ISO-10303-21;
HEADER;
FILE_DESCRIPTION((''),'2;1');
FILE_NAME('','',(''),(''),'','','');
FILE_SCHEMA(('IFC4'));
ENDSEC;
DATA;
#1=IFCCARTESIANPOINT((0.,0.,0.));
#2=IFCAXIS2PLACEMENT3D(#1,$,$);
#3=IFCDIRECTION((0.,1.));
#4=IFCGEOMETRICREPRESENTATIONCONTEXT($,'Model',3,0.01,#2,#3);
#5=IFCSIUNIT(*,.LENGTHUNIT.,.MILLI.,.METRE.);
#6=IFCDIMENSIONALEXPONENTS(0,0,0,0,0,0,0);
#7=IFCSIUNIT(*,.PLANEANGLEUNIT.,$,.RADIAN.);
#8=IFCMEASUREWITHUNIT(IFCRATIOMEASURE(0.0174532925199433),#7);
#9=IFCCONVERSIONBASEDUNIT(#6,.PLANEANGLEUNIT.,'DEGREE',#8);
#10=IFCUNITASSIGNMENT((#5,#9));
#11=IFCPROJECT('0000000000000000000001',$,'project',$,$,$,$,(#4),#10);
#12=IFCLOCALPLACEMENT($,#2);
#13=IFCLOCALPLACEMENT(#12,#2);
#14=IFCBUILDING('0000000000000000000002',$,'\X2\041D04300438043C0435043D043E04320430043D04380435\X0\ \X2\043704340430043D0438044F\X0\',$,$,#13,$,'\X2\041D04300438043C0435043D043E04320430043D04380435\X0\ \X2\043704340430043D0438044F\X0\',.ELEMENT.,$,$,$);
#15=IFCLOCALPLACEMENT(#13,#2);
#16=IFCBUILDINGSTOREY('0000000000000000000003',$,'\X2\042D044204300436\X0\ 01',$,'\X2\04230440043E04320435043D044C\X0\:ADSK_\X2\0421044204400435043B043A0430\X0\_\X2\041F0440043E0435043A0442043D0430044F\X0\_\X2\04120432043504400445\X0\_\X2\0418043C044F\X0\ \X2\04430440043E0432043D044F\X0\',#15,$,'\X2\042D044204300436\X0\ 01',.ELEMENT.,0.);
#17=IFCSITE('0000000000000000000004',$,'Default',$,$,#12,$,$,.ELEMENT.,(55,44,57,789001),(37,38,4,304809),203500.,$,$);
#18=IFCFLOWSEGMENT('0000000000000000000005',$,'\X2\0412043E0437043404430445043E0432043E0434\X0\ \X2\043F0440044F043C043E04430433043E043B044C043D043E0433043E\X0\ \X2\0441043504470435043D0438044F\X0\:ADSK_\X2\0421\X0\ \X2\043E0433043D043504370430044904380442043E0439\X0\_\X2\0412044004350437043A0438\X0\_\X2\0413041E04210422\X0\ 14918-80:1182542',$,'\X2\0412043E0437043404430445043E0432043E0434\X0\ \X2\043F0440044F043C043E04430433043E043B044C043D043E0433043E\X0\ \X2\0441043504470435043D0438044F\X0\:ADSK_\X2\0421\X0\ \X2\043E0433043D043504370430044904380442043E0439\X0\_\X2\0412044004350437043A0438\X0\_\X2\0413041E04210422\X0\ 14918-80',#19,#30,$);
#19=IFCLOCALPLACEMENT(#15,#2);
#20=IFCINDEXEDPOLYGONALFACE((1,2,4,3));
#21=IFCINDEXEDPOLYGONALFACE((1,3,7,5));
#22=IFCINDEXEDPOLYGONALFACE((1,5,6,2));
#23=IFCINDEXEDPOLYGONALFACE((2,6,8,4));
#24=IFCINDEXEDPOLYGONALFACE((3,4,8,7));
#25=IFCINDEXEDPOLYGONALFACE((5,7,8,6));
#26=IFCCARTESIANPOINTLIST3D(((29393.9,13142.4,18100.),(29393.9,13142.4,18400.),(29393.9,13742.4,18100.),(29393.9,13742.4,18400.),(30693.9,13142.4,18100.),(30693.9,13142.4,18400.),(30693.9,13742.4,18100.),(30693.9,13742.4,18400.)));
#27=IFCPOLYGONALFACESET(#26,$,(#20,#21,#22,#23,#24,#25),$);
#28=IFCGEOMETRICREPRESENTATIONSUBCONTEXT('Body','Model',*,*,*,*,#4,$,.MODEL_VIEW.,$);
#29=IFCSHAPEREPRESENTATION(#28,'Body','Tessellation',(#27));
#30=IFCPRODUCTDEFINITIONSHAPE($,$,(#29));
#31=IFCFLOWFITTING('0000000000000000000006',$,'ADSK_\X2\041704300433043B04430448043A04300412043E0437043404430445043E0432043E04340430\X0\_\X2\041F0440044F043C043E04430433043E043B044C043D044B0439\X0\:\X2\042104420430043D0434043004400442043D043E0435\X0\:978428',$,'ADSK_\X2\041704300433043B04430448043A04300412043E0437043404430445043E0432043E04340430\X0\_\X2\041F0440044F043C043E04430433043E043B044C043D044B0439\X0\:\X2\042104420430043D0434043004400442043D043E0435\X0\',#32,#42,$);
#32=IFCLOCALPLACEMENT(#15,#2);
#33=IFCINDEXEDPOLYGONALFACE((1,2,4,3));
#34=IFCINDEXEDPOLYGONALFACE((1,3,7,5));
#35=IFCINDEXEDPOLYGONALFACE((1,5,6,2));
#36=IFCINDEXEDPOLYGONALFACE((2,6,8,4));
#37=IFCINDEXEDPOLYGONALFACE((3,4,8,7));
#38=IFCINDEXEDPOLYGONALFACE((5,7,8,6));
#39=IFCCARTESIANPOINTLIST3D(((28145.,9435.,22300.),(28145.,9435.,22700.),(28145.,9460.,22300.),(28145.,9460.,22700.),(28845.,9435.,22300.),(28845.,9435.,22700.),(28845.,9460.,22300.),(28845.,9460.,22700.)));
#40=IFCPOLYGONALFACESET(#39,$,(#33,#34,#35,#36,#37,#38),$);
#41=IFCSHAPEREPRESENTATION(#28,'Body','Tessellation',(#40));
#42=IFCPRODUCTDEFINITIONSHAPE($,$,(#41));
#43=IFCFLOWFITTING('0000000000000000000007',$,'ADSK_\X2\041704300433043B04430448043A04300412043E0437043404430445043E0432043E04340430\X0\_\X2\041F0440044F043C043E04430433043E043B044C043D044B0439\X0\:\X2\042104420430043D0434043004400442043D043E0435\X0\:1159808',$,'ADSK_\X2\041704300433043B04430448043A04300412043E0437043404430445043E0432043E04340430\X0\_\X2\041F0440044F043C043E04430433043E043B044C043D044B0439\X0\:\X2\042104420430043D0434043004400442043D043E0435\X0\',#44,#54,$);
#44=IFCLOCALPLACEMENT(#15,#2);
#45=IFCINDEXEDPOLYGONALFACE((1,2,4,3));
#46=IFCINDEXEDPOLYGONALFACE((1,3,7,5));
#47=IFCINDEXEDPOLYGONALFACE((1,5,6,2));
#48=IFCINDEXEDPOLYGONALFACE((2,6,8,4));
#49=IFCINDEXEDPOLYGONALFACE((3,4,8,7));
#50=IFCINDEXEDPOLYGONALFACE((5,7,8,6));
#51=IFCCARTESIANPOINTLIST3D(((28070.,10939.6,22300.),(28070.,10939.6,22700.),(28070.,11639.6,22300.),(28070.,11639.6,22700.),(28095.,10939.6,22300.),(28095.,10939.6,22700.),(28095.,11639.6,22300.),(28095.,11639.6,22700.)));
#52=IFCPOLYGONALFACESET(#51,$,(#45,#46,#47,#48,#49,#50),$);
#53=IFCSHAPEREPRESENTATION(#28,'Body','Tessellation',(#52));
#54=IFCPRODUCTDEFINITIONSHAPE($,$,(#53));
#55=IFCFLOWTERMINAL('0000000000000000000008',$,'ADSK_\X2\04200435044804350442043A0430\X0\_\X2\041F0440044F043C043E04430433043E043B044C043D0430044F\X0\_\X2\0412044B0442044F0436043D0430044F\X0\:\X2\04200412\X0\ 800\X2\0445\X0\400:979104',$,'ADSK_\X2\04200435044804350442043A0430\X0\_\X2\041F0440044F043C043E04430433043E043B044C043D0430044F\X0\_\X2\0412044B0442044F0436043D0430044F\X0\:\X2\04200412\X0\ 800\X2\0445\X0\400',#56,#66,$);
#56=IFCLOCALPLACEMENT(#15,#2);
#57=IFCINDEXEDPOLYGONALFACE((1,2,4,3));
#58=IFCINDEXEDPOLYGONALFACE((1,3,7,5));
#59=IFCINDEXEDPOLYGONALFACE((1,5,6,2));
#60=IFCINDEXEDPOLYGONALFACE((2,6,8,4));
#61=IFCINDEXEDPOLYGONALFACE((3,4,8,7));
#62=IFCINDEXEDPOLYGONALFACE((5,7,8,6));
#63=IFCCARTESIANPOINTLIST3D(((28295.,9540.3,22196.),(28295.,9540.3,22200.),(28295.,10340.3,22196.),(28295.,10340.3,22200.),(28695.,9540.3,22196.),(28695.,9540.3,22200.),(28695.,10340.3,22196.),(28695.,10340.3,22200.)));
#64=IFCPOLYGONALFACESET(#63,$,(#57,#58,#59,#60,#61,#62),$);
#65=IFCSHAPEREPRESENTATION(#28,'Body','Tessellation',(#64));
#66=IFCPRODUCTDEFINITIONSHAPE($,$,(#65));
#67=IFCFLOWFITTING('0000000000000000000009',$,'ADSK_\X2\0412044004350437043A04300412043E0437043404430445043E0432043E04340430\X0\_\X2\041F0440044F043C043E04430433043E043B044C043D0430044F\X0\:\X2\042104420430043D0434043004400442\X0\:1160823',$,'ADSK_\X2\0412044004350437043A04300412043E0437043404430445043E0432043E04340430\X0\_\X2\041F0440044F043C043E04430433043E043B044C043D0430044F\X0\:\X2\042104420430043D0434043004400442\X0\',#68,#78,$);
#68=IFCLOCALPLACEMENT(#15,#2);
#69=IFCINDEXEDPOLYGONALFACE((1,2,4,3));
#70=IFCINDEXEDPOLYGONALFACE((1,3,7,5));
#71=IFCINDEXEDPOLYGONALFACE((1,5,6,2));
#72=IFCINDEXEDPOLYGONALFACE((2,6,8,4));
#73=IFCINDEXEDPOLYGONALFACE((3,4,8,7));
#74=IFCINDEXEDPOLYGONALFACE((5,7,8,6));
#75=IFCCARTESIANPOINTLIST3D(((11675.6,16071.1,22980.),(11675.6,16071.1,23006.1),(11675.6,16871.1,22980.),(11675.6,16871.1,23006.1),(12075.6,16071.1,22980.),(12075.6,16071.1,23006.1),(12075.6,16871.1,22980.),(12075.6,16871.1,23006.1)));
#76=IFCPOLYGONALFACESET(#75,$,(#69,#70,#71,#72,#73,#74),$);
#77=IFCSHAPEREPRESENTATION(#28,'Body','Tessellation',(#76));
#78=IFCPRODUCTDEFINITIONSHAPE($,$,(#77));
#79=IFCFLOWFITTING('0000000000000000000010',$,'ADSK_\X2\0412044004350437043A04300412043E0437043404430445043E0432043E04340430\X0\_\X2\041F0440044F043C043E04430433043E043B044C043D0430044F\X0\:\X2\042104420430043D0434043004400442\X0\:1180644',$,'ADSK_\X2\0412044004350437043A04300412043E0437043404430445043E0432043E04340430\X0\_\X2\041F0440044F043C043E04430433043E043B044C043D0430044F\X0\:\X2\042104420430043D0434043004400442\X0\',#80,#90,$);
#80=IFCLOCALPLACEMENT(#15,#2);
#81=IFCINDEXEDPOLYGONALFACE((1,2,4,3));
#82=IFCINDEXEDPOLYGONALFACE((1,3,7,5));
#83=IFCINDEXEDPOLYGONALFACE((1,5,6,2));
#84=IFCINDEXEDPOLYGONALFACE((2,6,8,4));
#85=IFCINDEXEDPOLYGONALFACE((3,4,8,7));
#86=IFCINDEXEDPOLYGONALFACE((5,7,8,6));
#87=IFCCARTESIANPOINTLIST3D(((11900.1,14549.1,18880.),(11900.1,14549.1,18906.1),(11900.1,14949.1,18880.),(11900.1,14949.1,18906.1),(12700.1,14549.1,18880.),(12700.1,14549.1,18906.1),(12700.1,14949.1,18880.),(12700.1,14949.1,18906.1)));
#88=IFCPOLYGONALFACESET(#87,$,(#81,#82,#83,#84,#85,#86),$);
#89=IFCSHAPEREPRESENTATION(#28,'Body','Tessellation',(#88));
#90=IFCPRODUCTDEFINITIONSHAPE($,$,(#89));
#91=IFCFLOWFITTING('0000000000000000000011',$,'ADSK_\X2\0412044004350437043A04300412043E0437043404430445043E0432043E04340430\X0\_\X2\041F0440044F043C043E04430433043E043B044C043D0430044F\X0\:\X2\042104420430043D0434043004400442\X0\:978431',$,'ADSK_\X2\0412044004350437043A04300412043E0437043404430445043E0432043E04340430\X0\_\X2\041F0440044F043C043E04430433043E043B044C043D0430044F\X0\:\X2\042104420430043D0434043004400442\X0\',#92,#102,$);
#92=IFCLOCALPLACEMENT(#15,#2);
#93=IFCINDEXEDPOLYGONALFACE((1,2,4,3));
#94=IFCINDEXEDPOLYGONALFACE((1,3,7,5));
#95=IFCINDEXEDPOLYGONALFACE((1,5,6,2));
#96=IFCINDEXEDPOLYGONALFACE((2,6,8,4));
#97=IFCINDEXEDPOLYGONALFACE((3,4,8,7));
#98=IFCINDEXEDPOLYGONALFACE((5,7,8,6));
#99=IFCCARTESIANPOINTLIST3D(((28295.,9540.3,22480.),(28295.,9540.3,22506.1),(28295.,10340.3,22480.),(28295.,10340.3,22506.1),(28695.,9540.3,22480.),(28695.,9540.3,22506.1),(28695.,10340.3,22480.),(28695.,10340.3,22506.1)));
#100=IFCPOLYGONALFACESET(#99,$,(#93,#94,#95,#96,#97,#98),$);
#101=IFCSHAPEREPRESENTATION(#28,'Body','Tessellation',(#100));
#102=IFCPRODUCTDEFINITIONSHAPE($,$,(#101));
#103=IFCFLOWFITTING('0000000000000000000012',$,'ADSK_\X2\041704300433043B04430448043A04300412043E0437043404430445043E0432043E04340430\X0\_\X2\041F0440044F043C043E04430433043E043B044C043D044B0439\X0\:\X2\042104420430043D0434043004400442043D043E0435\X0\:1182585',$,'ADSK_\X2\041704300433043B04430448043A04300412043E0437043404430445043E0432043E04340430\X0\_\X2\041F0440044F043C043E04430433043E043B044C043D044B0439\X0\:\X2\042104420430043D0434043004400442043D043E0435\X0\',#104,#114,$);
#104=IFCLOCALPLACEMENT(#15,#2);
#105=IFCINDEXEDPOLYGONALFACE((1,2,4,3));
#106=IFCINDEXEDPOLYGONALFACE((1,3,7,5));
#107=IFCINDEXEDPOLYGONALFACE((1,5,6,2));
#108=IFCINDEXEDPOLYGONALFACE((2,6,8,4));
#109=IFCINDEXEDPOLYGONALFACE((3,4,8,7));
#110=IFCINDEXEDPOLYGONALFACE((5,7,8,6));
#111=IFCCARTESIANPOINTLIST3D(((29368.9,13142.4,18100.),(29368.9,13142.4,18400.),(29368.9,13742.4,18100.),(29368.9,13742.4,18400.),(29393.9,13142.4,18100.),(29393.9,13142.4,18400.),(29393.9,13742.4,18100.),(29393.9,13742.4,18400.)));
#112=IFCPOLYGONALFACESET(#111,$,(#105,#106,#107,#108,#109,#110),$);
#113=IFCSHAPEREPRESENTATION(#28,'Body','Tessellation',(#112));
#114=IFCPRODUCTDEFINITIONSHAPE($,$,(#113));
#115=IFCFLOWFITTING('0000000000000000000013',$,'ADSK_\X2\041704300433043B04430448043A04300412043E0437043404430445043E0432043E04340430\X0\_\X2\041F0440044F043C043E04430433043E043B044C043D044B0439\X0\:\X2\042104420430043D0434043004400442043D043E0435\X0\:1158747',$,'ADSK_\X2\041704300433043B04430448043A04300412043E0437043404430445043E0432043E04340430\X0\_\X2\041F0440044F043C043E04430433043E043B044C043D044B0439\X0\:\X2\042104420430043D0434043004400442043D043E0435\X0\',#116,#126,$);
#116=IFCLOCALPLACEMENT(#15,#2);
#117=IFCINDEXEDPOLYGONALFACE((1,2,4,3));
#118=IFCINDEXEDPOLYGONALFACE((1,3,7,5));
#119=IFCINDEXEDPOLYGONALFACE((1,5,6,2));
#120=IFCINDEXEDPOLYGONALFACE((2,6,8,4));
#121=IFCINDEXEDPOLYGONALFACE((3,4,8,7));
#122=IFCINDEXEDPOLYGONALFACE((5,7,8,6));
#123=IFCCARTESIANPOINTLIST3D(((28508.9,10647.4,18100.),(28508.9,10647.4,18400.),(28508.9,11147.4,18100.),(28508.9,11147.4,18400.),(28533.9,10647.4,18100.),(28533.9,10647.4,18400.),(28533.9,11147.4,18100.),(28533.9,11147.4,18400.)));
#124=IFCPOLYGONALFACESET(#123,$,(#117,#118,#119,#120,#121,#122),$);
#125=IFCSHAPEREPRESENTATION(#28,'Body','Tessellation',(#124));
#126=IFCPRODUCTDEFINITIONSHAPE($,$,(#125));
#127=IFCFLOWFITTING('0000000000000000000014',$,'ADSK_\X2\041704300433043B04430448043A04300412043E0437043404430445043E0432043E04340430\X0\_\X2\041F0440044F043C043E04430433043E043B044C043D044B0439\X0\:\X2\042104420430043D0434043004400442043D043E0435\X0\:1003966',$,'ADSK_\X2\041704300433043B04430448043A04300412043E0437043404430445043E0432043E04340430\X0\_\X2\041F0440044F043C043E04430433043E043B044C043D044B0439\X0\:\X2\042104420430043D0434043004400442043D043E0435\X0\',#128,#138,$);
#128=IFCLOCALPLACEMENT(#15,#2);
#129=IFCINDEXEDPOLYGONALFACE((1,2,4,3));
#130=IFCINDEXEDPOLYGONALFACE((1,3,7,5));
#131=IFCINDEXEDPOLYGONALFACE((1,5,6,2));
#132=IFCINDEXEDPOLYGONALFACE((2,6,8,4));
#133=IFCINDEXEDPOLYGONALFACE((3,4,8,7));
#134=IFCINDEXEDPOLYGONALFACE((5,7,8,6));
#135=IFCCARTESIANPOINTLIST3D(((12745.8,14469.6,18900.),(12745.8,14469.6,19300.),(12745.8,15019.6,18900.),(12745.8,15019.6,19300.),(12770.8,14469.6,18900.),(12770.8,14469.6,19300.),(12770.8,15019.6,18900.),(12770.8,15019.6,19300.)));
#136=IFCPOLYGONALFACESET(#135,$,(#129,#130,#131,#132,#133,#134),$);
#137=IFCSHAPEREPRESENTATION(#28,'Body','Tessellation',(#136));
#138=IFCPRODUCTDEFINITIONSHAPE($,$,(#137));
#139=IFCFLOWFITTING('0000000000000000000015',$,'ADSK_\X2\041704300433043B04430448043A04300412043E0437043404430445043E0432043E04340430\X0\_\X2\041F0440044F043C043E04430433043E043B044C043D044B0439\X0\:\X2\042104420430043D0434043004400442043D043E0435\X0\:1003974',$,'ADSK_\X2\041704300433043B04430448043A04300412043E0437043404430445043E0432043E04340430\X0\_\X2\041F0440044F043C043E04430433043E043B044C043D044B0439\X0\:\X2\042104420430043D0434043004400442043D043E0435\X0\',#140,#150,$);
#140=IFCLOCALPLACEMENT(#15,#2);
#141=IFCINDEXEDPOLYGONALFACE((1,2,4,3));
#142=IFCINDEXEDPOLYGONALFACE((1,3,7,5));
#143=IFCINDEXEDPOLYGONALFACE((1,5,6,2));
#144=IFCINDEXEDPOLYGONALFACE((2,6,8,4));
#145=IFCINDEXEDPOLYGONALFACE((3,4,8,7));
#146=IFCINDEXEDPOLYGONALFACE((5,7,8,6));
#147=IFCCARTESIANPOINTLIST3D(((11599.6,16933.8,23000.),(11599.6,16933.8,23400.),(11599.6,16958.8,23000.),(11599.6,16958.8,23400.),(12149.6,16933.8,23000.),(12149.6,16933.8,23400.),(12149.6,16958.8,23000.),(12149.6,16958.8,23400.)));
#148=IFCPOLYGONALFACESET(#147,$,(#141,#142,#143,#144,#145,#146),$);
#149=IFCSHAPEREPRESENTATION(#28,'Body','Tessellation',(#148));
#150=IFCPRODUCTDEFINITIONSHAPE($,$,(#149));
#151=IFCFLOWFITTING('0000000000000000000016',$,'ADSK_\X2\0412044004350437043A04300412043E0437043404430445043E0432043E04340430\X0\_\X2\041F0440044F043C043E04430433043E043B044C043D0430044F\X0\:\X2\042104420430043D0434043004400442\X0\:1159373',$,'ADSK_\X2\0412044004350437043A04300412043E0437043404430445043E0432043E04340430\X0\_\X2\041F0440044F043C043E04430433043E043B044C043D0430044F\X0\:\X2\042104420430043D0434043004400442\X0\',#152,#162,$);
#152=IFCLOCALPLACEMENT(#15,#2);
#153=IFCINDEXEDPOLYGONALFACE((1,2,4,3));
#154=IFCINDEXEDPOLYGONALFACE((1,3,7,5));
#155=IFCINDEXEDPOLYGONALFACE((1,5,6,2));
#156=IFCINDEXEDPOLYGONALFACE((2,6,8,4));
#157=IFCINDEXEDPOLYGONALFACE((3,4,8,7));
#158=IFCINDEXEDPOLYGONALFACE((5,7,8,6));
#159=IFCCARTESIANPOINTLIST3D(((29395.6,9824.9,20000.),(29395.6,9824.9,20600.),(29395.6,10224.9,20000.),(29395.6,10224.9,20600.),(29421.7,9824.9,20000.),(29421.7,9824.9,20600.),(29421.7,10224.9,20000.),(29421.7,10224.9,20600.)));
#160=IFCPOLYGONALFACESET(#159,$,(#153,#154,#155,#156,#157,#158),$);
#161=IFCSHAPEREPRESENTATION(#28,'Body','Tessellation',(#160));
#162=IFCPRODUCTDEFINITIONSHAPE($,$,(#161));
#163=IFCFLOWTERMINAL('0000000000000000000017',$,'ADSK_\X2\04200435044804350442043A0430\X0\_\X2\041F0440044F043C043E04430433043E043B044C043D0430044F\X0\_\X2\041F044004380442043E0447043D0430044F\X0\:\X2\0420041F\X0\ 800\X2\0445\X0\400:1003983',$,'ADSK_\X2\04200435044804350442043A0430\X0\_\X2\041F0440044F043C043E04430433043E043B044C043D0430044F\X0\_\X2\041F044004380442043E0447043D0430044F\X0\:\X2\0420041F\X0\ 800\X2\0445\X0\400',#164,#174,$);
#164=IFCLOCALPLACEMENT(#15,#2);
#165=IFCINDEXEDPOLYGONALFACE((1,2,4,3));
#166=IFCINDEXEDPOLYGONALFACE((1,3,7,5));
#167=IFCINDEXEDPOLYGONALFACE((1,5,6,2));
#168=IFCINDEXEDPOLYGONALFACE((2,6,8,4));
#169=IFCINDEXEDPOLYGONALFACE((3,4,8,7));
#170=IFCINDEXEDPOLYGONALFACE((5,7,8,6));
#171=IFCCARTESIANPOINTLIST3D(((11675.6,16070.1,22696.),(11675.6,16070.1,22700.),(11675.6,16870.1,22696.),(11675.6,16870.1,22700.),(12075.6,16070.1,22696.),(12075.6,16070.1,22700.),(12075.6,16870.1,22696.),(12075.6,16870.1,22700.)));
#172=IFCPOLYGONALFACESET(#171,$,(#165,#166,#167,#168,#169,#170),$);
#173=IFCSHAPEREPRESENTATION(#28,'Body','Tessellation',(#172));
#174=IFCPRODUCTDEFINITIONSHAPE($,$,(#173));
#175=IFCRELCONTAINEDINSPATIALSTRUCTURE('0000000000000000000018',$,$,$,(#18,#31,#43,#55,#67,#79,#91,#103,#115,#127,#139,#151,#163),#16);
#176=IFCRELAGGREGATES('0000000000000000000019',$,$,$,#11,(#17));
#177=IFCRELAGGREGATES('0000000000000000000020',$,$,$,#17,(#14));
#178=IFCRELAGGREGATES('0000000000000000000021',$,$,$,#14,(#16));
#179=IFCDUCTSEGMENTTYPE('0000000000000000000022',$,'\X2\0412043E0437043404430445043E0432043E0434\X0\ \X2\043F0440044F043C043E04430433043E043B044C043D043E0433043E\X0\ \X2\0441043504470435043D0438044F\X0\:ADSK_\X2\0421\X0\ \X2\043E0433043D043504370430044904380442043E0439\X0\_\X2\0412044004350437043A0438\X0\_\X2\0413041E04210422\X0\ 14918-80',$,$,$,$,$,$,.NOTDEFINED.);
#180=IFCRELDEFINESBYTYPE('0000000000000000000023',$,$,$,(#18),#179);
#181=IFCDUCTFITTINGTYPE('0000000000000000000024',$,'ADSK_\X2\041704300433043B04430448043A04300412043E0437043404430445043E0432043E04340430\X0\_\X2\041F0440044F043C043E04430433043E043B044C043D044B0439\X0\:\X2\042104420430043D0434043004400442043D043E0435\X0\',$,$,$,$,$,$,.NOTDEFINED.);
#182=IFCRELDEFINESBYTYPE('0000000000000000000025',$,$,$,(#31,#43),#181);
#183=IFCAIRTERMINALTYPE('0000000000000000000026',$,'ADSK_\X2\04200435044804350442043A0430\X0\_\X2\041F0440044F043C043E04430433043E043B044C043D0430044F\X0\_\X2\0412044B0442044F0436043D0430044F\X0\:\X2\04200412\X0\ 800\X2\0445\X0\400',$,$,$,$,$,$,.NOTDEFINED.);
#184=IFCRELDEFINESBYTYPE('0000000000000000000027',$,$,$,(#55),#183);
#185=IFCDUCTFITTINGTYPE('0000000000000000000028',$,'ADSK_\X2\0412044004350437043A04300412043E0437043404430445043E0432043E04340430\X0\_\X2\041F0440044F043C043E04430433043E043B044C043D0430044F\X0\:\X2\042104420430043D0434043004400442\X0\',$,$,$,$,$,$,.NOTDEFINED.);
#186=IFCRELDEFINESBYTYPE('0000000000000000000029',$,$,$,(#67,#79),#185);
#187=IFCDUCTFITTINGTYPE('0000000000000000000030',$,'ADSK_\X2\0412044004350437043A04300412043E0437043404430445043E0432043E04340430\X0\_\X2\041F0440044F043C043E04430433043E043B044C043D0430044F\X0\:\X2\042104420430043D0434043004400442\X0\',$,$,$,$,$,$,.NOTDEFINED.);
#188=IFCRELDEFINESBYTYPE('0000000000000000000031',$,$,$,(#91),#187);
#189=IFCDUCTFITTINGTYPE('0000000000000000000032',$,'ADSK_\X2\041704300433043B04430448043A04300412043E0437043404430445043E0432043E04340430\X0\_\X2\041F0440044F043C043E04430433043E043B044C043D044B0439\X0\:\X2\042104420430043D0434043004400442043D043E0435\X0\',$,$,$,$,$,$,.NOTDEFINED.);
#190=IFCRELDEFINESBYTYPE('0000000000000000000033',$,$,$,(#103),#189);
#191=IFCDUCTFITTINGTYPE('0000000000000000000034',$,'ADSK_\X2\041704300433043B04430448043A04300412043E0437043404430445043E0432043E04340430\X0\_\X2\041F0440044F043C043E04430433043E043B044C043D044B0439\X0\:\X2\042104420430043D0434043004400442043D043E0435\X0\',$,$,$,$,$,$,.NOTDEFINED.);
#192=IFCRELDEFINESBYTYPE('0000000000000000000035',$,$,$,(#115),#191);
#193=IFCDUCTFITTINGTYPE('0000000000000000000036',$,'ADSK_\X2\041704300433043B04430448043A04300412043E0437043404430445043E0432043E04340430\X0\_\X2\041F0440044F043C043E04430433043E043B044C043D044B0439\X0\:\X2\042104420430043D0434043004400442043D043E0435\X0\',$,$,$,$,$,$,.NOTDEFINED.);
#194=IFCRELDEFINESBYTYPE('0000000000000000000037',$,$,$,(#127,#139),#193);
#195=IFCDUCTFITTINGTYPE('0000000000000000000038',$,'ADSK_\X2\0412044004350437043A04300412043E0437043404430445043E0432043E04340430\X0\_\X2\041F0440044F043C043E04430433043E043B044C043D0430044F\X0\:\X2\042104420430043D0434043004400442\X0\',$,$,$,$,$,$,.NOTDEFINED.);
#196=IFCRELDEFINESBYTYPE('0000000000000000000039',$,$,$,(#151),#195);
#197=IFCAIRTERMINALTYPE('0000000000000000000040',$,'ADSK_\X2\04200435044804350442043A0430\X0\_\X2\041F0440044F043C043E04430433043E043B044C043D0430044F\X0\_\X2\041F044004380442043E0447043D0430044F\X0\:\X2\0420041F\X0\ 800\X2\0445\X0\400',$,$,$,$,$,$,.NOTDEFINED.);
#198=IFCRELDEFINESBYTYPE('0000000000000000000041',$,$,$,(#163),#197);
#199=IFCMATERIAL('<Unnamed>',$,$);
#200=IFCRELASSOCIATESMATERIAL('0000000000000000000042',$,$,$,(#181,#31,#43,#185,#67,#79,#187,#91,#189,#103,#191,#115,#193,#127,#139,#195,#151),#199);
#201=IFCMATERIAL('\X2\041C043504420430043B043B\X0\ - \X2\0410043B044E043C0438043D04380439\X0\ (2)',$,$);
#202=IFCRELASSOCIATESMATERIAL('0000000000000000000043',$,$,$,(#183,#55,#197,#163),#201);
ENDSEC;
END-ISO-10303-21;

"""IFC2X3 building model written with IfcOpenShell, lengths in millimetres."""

from ifc_helpers import new_model, entity, si_unit, converted_unit, direction, frame, origin, origin_2d_with_axis, place, context, subcontext, project, spatial, rectangle, extrude, source, transform, mapped, material, type_object, type_shapes, element, save


model = new_model("IFC2X3")

# Units and contexts
model_context = context("Model", 3, precision=0.01, world=origin(), true_north=direction((0.0, 1.0)))
body_context = subcontext(model_context, "Body", "Model", "MODEL_VIEW")
ifc_project = project(units=[si_unit("LENGTHUNIT", "METRE", prefix="MILLI"), converted_unit("PLANEANGLEUNIT", "DEGREE", entity("IfcRatioMeasure", 0.0174532925199433), si_unit("PLANEANGLEUNIT", "RADIAN"), dimensions=[0, 0, 0, 0, 0, 0, 0])], contexts=[model_context])

# Site, building, storey
site_placement = place(None, origin())
site = spatial("IfcSite", under=ifc_project, at=site_placement, Name="Default", CompositionType="ELEMENT", RefLatitude=(55, 44, 57, 789001), RefLongitude=(37, 38, 4, 304809), RefElevation=203500.0)
building_placement = place(site_placement, origin())
building = spatial("IfcBuilding", under=site, at=building_placement, Name="Наименование здания", LongName="Наименование здания", CompositionType="ELEMENT")
storey_placement = place(building_placement, origin())
storey = spatial("IfcBuildingStorey", under=building, at=storey_placement, Name="Этаж 01", ObjectType="Уровень:ADSK_Стрелка_Проектная_Вверх_Имя уровня", LongName="Этаж 01", CompositionType="ELEMENT", Elevation=0.0)

# Flow segment
duct_segment_type = type_object("IfcDuctSegmentType", Name="Воздуховод прямоугольного сечения:ADSK_С огнезащитой_Врезки_ГОСТ 14918-80", PredefinedType="NOTDEFINED")
for number, where, name in (
    (1, (29393.9, 13142.4, 18100.0), "Воздуховод прямоугольного сечения:ADSK_С огнезащитой_Врезки_ГОСТ 14918-80:1182542"),
):
    element("IfcFlowSegment", number, at=place(storey_placement, frame(where)), inside=storey, type_object=duct_segment_type, Name=name, ObjectType="Воздуховод прямоугольного сечения:ADSK_С огнезащитой_Врезки_ГОСТ 14918-80", context=body_context, shape_type="SweptSolid", body=[
        extrude(rectangle(XDim=1300.0, YDim=600.0, at=origin_2d_with_axis()), frame((650.0, 300.0, 0.0), z_axis=(0.0, 0.0, 1.0), x_axis=(-1.0, 0.0, 0.0)), (0.0, 0.0, 1.0), 300.0),
    ])

# Flow fittings
ifc_material_1 = material(Name="<Unnamed>")
duct_fitting_type_1 = type_object("IfcDuctFittingType", Name="ADSK_ЗаглушкаВоздуховода_Прямоугольный:Стандартное", PredefinedType="NOTDEFINED", material=ifc_material_1)
shared_shape_1 = source(origin(), body_context, "Body", "SweptSolid", [
    extrude(rectangle(XDim=25.0, YDim=700.0, at=origin_2d_with_axis()), frame((12.5, 0.0, -200.0)), (0.0, 0.0, 1.0), 400.0),
])
type_shapes(duct_fitting_type_1, [shared_shape_1])
for number, where, z_axis, x_axis, name in (
    (2, (28495.0, 9460.0, 22500.0), (0.0, 0.0, 1.0), (0.0, -1.0, 0.0), "ADSK_ЗаглушкаВоздуховода_Прямоугольный:Стандартное:978428"),
    (3, (28095.0, 11289.6, 22500.0), (0.0, 0.0, 1.0), (-1.0, 0.0, 0.0), "ADSK_ЗаглушкаВоздуховода_Прямоугольный:Стандартное:1159808"),
):
    element("IfcFlowFitting", number, at=place(storey_placement, frame(where, z_axis=z_axis, x_axis=x_axis)), inside=storey, type_object=duct_fitting_type_1, material=ifc_material_1, Name=name, ObjectType="ADSK_ЗаглушкаВоздуховода_Прямоугольный:Стандартное", context=body_context, shape_type="MappedRepresentation", body=[
        mapped(shared_shape_1, transform((0.0, 0.0, 0.0), scale=1.0)),
    ])

# Flow terminal
ifc_material_2 = material(Name="Металл - Алюминий (2)")
air_terminal_type_1 = type_object("IfcAirTerminalType", Name="ADSK_Решетка_Прямоугольная_Вытяжная:РВ 800х400", PredefinedType="NOTDEFINED", material=ifc_material_2)
shared_shape_2 = source(origin(), body_context, "Body", "SweptSolid", [
    extrude(rectangle(XDim=4.0, YDim=800.0, at=origin_2d_with_axis()), frame((0.0, -2.0, -200.0), z_axis=(0.0, 0.0, 1.0), x_axis=(0.0, 1.0, 0.0)), (0.0, 0.0, 1.0), 400.0),
])
type_shapes(air_terminal_type_1, [shared_shape_2])
flow_terminal_1_placement = place(storey_placement, frame((28495.0, 9940.3, 22200.0), z_axis=(-1.0, 0.0, 0.0), x_axis=(0.0, -1.0, 0.0)))
element("IfcFlowTerminal", 4, at=flow_terminal_1_placement, inside=storey, type_object=air_terminal_type_1, material=ifc_material_2, Name="ADSK_Решетка_Прямоугольная_Вытяжная:РВ 800х400:979104", ObjectType="ADSK_Решетка_Прямоугольная_Вытяжная:РВ 800х400", context=body_context, shape_type="MappedRepresentation", body=[
    mapped(shared_shape_2, transform((0.0, 0.0, 0.0), scale=1.0)),
])

# Flow fittings
duct_fitting_type_2 = type_object("IfcDuctFittingType", Name="ADSK_ВрезкаВоздуховода_Прямоугольная:Стандарт", PredefinedType="NOTDEFINED", material=ifc_material_1)
shared_shape_3 = source(origin(), body_context, "Body", "SweptSolid", [
    extrude(rectangle(XDim=26.1, YDim=800.0, at=origin_2d_with_axis()), frame((7.0, 0.0, -200.0)), (0.0, 0.0, 1.0), 400.0),
])
type_shapes(duct_fitting_type_2, [shared_shape_3])
for number, where, z_axis, x_axis, name in (
    (5, (11875.6, 16471.1, 23000.0), (1.0, 0.0, 0.0), (0.0, 0.0, -1.0), "ADSK_ВрезкаВоздуховода_Прямоугольная:Стандарт:1160823"),
    (6, (12300.1, 14749.1, 18900.0), (0.0, 1.0, 0.0), (0.0, 0.0, -1.0), "ADSK_ВрезкаВоздуховода_Прямоугольная:Стандарт:1180644"),
):
    element("IfcFlowFitting", number, at=place(storey_placement, frame(where, z_axis=z_axis, x_axis=x_axis)), inside=storey, type_object=duct_fitting_type_2, material=ifc_material_1, Name=name, ObjectType="ADSK_ВрезкаВоздуховода_Прямоугольная:Стандарт", context=body_context, shape_type="MappedRepresentation", body=[
        mapped(shared_shape_3, transform((0.0, 0.0, 0.0), scale=1.0)),
    ])
duct_fitting_type_3 = type_object("IfcDuctFittingType", Name="ADSK_ВрезкаВоздуховода_Прямоугольная:Стандарт", PredefinedType="NOTDEFINED", material=ifc_material_1)
shared_shape_4 = source(origin(), body_context, "Body", "SweptSolid", [
    extrude(rectangle(XDim=800.0, YDim=26.1, at=origin_2d_with_axis()), frame((7.0, 0.0, -200.0), z_axis=(0.0, 0.0, 1.0), x_axis=(0.0, -1.0, 0.0)), (0.0, 0.0, 1.0), 400.0),
])
type_shapes(duct_fitting_type_3, [shared_shape_4])
flow_fitting_1_placement = place(storey_placement, frame((28495.0, 9940.3, 22500.0), z_axis=(-1.0, 0.0, 0.0), x_axis=(0.0, 0.0, -1.0)))
element("IfcFlowFitting", 7, at=flow_fitting_1_placement, inside=storey, type_object=duct_fitting_type_3, material=ifc_material_1, Name="ADSK_ВрезкаВоздуховода_Прямоугольная:Стандарт:978431", ObjectType="ADSK_ВрезкаВоздуховода_Прямоугольная:Стандарт", context=body_context, shape_type="MappedRepresentation", body=[
    mapped(shared_shape_4, transform((0.0, 0.0, 0.0), scale=1.0)),
])
duct_fitting_type_4 = type_object("IfcDuctFittingType", Name="ADSK_ЗаглушкаВоздуховода_Прямоугольный:Стандартное", PredefinedType="NOTDEFINED", material=ifc_material_1)
shared_shape_5 = source(origin(), body_context, "Body", "SweptSolid", [
    extrude(rectangle(XDim=25.0, YDim=600.0, at=origin_2d_with_axis()), frame((12.5, 0.0, -150.0)), (0.0, 0.0, 1.0), 300.0),
])
type_shapes(duct_fitting_type_4, [shared_shape_5])
flow_fitting_2_placement = place(storey_placement, frame((29393.9, 13442.4, 18250.0), z_axis=(0.0, 0.0, 1.0), x_axis=(-1.0, 0.0, 0.0)))
element("IfcFlowFitting", 8, at=flow_fitting_2_placement, inside=storey, type_object=duct_fitting_type_4, material=ifc_material_1, Name="ADSK_ЗаглушкаВоздуховода_Прямоугольный:Стандартное:1182585", ObjectType="ADSK_ЗаглушкаВоздуховода_Прямоугольный:Стандартное", context=body_context, shape_type="MappedRepresentation", body=[
    mapped(shared_shape_5, transform((0.0, 0.0, 0.0), scale=1.0)),
])
duct_fitting_type_5 = type_object("IfcDuctFittingType", Name="ADSK_ЗаглушкаВоздуховода_Прямоугольный:Стандартное", PredefinedType="NOTDEFINED", material=ifc_material_1)
shared_shape_6 = source(origin(), body_context, "Body", "SweptSolid", [
    extrude(rectangle(XDim=25.0, YDim=500.0, at=origin_2d_with_axis()), frame((12.5, 0.0, -150.0)), (0.0, 0.0, 1.0), 300.0),
])
type_shapes(duct_fitting_type_5, [shared_shape_6])
flow_fitting_3_placement = place(storey_placement, frame((28533.9, 10897.4, 18250.0), z_axis=(0.0, 0.0, 1.0), x_axis=(-1.0, 0.0, 0.0)))
element("IfcFlowFitting", 9, at=flow_fitting_3_placement, inside=storey, type_object=duct_fitting_type_5, material=ifc_material_1, Name="ADSK_ЗаглушкаВоздуховода_Прямоугольный:Стандартное:1158747", ObjectType="ADSK_ЗаглушкаВоздуховода_Прямоугольный:Стандартное", context=body_context, shape_type="MappedRepresentation", body=[
    mapped(shared_shape_6, transform((0.0, 0.0, 0.0), scale=1.0)),
])
duct_fitting_type_6 = type_object("IfcDuctFittingType", Name="ADSK_ЗаглушкаВоздуховода_Прямоугольный:Стандартное", PredefinedType="NOTDEFINED", material=ifc_material_1)
shared_shape_7 = source(origin(), body_context, "Body", "SweptSolid", [
    extrude(rectangle(XDim=25.0, YDim=550.0, at=origin_2d_with_axis()), frame((12.5, 0.0, -200.0)), (0.0, 0.0, 1.0), 400.0),
])
type_shapes(duct_fitting_type_6, [shared_shape_7])
flow_fitting_4_placement = place(storey_placement, frame((12745.8, 14744.6, 19100.0)))
element("IfcFlowFitting", 10, at=flow_fitting_4_placement, inside=storey, type_object=duct_fitting_type_6, material=ifc_material_1, Name="ADSK_ЗаглушкаВоздуховода_Прямоугольный:Стандартное:1003966", ObjectType="ADSK_ЗаглушкаВоздуховода_Прямоугольный:Стандартное", context=body_context, shape_type="MappedRepresentation", body=[
    mapped(shared_shape_7, transform((0.0, 0.0, 0.0), scale=1.0)),
])
flow_fitting_5_placement = place(storey_placement, frame((11874.6, 16933.8, 23200.0), z_axis=(0.0, 0.0, 1.0), x_axis=(0.0, 1.0, 0.0)))
element("IfcFlowFitting", 11, at=flow_fitting_5_placement, inside=storey, type_object=duct_fitting_type_6, material=ifc_material_1, Name="ADSK_ЗаглушкаВоздуховода_Прямоугольный:Стандартное:1003974", ObjectType="ADSK_ЗаглушкаВоздуховода_Прямоугольный:Стандартное", context=body_context, shape_type="MappedRepresentation", body=[
    mapped(shared_shape_7, transform((0.0, 0.0, 0.0), scale=1.0)),
])
duct_fitting_type_7 = type_object("IfcDuctFittingType", Name="ADSK_ВрезкаВоздуховода_Прямоугольная:Стандарт", PredefinedType="NOTDEFINED", material=ifc_material_1)
shared_shape_8 = source(origin(), body_context, "Body", "SweptSolid", [
    extrude(rectangle(XDim=600.0, YDim=26.1, at=origin_2d_with_axis()), frame((7.0, 0.0, -200.0), z_axis=(0.0, 0.0, 1.0), x_axis=(0.0, -1.0, 0.0)), (0.0, 0.0, 1.0), 400.0),
])
type_shapes(duct_fitting_type_7, [shared_shape_8])
flow_fitting_6_placement = place(storey_placement, frame((29415.6, 10024.9, 20300.0), z_axis=(0.0, 1.0, 0.0), x_axis=(-1.0, 0.0, 0.0)))
element("IfcFlowFitting", 12, at=flow_fitting_6_placement, inside=storey, type_object=duct_fitting_type_7, material=ifc_material_1, Name="ADSK_ВрезкаВоздуховода_Прямоугольная:Стандарт:1159373", ObjectType="ADSK_ВрезкаВоздуховода_Прямоугольная:Стандарт", context=body_context, shape_type="MappedRepresentation", body=[
    mapped(shared_shape_8, transform((0.0, 0.0, 0.0), scale=1.0)),
])

# Flow terminal
air_terminal_type_2 = type_object("IfcAirTerminalType", Name="ADSK_Решетка_Прямоугольная_Приточная:РП 800х400", PredefinedType="NOTDEFINED", material=ifc_material_2)
shared_shape_9 = source(origin(), body_context, "Body", "SweptSolid", [
    extrude(rectangle(XDim=4.0, YDim=800.0, at=origin_2d_with_axis()), frame((0.0, -2.0, -200.0), z_axis=(0.0, 0.0, 1.0), x_axis=(0.0, 1.0, 0.0)), (0.0, 0.0, 1.0), 400.0),
])
type_shapes(air_terminal_type_2, [shared_shape_9])
flow_terminal_2_placement = place(storey_placement, frame((11875.6, 16470.1, 22700.0), z_axis=(-1.0, 0.0, 0.0), x_axis=(0.0, -1.0, 0.0)))
element("IfcFlowTerminal", 13, at=flow_terminal_2_placement, inside=storey, type_object=air_terminal_type_2, material=ifc_material_2, Name="ADSK_Решетка_Прямоугольная_Приточная:РП 800х400:1003983", ObjectType="ADSK_Решетка_Прямоугольная_Приточная:РП 800х400", context=body_context, shape_type="MappedRepresentation", body=[
    mapped(shared_shape_9, transform((0.0, 0.0, 0.0), scale=1.0)),
])

save(model, "model.ifc")
